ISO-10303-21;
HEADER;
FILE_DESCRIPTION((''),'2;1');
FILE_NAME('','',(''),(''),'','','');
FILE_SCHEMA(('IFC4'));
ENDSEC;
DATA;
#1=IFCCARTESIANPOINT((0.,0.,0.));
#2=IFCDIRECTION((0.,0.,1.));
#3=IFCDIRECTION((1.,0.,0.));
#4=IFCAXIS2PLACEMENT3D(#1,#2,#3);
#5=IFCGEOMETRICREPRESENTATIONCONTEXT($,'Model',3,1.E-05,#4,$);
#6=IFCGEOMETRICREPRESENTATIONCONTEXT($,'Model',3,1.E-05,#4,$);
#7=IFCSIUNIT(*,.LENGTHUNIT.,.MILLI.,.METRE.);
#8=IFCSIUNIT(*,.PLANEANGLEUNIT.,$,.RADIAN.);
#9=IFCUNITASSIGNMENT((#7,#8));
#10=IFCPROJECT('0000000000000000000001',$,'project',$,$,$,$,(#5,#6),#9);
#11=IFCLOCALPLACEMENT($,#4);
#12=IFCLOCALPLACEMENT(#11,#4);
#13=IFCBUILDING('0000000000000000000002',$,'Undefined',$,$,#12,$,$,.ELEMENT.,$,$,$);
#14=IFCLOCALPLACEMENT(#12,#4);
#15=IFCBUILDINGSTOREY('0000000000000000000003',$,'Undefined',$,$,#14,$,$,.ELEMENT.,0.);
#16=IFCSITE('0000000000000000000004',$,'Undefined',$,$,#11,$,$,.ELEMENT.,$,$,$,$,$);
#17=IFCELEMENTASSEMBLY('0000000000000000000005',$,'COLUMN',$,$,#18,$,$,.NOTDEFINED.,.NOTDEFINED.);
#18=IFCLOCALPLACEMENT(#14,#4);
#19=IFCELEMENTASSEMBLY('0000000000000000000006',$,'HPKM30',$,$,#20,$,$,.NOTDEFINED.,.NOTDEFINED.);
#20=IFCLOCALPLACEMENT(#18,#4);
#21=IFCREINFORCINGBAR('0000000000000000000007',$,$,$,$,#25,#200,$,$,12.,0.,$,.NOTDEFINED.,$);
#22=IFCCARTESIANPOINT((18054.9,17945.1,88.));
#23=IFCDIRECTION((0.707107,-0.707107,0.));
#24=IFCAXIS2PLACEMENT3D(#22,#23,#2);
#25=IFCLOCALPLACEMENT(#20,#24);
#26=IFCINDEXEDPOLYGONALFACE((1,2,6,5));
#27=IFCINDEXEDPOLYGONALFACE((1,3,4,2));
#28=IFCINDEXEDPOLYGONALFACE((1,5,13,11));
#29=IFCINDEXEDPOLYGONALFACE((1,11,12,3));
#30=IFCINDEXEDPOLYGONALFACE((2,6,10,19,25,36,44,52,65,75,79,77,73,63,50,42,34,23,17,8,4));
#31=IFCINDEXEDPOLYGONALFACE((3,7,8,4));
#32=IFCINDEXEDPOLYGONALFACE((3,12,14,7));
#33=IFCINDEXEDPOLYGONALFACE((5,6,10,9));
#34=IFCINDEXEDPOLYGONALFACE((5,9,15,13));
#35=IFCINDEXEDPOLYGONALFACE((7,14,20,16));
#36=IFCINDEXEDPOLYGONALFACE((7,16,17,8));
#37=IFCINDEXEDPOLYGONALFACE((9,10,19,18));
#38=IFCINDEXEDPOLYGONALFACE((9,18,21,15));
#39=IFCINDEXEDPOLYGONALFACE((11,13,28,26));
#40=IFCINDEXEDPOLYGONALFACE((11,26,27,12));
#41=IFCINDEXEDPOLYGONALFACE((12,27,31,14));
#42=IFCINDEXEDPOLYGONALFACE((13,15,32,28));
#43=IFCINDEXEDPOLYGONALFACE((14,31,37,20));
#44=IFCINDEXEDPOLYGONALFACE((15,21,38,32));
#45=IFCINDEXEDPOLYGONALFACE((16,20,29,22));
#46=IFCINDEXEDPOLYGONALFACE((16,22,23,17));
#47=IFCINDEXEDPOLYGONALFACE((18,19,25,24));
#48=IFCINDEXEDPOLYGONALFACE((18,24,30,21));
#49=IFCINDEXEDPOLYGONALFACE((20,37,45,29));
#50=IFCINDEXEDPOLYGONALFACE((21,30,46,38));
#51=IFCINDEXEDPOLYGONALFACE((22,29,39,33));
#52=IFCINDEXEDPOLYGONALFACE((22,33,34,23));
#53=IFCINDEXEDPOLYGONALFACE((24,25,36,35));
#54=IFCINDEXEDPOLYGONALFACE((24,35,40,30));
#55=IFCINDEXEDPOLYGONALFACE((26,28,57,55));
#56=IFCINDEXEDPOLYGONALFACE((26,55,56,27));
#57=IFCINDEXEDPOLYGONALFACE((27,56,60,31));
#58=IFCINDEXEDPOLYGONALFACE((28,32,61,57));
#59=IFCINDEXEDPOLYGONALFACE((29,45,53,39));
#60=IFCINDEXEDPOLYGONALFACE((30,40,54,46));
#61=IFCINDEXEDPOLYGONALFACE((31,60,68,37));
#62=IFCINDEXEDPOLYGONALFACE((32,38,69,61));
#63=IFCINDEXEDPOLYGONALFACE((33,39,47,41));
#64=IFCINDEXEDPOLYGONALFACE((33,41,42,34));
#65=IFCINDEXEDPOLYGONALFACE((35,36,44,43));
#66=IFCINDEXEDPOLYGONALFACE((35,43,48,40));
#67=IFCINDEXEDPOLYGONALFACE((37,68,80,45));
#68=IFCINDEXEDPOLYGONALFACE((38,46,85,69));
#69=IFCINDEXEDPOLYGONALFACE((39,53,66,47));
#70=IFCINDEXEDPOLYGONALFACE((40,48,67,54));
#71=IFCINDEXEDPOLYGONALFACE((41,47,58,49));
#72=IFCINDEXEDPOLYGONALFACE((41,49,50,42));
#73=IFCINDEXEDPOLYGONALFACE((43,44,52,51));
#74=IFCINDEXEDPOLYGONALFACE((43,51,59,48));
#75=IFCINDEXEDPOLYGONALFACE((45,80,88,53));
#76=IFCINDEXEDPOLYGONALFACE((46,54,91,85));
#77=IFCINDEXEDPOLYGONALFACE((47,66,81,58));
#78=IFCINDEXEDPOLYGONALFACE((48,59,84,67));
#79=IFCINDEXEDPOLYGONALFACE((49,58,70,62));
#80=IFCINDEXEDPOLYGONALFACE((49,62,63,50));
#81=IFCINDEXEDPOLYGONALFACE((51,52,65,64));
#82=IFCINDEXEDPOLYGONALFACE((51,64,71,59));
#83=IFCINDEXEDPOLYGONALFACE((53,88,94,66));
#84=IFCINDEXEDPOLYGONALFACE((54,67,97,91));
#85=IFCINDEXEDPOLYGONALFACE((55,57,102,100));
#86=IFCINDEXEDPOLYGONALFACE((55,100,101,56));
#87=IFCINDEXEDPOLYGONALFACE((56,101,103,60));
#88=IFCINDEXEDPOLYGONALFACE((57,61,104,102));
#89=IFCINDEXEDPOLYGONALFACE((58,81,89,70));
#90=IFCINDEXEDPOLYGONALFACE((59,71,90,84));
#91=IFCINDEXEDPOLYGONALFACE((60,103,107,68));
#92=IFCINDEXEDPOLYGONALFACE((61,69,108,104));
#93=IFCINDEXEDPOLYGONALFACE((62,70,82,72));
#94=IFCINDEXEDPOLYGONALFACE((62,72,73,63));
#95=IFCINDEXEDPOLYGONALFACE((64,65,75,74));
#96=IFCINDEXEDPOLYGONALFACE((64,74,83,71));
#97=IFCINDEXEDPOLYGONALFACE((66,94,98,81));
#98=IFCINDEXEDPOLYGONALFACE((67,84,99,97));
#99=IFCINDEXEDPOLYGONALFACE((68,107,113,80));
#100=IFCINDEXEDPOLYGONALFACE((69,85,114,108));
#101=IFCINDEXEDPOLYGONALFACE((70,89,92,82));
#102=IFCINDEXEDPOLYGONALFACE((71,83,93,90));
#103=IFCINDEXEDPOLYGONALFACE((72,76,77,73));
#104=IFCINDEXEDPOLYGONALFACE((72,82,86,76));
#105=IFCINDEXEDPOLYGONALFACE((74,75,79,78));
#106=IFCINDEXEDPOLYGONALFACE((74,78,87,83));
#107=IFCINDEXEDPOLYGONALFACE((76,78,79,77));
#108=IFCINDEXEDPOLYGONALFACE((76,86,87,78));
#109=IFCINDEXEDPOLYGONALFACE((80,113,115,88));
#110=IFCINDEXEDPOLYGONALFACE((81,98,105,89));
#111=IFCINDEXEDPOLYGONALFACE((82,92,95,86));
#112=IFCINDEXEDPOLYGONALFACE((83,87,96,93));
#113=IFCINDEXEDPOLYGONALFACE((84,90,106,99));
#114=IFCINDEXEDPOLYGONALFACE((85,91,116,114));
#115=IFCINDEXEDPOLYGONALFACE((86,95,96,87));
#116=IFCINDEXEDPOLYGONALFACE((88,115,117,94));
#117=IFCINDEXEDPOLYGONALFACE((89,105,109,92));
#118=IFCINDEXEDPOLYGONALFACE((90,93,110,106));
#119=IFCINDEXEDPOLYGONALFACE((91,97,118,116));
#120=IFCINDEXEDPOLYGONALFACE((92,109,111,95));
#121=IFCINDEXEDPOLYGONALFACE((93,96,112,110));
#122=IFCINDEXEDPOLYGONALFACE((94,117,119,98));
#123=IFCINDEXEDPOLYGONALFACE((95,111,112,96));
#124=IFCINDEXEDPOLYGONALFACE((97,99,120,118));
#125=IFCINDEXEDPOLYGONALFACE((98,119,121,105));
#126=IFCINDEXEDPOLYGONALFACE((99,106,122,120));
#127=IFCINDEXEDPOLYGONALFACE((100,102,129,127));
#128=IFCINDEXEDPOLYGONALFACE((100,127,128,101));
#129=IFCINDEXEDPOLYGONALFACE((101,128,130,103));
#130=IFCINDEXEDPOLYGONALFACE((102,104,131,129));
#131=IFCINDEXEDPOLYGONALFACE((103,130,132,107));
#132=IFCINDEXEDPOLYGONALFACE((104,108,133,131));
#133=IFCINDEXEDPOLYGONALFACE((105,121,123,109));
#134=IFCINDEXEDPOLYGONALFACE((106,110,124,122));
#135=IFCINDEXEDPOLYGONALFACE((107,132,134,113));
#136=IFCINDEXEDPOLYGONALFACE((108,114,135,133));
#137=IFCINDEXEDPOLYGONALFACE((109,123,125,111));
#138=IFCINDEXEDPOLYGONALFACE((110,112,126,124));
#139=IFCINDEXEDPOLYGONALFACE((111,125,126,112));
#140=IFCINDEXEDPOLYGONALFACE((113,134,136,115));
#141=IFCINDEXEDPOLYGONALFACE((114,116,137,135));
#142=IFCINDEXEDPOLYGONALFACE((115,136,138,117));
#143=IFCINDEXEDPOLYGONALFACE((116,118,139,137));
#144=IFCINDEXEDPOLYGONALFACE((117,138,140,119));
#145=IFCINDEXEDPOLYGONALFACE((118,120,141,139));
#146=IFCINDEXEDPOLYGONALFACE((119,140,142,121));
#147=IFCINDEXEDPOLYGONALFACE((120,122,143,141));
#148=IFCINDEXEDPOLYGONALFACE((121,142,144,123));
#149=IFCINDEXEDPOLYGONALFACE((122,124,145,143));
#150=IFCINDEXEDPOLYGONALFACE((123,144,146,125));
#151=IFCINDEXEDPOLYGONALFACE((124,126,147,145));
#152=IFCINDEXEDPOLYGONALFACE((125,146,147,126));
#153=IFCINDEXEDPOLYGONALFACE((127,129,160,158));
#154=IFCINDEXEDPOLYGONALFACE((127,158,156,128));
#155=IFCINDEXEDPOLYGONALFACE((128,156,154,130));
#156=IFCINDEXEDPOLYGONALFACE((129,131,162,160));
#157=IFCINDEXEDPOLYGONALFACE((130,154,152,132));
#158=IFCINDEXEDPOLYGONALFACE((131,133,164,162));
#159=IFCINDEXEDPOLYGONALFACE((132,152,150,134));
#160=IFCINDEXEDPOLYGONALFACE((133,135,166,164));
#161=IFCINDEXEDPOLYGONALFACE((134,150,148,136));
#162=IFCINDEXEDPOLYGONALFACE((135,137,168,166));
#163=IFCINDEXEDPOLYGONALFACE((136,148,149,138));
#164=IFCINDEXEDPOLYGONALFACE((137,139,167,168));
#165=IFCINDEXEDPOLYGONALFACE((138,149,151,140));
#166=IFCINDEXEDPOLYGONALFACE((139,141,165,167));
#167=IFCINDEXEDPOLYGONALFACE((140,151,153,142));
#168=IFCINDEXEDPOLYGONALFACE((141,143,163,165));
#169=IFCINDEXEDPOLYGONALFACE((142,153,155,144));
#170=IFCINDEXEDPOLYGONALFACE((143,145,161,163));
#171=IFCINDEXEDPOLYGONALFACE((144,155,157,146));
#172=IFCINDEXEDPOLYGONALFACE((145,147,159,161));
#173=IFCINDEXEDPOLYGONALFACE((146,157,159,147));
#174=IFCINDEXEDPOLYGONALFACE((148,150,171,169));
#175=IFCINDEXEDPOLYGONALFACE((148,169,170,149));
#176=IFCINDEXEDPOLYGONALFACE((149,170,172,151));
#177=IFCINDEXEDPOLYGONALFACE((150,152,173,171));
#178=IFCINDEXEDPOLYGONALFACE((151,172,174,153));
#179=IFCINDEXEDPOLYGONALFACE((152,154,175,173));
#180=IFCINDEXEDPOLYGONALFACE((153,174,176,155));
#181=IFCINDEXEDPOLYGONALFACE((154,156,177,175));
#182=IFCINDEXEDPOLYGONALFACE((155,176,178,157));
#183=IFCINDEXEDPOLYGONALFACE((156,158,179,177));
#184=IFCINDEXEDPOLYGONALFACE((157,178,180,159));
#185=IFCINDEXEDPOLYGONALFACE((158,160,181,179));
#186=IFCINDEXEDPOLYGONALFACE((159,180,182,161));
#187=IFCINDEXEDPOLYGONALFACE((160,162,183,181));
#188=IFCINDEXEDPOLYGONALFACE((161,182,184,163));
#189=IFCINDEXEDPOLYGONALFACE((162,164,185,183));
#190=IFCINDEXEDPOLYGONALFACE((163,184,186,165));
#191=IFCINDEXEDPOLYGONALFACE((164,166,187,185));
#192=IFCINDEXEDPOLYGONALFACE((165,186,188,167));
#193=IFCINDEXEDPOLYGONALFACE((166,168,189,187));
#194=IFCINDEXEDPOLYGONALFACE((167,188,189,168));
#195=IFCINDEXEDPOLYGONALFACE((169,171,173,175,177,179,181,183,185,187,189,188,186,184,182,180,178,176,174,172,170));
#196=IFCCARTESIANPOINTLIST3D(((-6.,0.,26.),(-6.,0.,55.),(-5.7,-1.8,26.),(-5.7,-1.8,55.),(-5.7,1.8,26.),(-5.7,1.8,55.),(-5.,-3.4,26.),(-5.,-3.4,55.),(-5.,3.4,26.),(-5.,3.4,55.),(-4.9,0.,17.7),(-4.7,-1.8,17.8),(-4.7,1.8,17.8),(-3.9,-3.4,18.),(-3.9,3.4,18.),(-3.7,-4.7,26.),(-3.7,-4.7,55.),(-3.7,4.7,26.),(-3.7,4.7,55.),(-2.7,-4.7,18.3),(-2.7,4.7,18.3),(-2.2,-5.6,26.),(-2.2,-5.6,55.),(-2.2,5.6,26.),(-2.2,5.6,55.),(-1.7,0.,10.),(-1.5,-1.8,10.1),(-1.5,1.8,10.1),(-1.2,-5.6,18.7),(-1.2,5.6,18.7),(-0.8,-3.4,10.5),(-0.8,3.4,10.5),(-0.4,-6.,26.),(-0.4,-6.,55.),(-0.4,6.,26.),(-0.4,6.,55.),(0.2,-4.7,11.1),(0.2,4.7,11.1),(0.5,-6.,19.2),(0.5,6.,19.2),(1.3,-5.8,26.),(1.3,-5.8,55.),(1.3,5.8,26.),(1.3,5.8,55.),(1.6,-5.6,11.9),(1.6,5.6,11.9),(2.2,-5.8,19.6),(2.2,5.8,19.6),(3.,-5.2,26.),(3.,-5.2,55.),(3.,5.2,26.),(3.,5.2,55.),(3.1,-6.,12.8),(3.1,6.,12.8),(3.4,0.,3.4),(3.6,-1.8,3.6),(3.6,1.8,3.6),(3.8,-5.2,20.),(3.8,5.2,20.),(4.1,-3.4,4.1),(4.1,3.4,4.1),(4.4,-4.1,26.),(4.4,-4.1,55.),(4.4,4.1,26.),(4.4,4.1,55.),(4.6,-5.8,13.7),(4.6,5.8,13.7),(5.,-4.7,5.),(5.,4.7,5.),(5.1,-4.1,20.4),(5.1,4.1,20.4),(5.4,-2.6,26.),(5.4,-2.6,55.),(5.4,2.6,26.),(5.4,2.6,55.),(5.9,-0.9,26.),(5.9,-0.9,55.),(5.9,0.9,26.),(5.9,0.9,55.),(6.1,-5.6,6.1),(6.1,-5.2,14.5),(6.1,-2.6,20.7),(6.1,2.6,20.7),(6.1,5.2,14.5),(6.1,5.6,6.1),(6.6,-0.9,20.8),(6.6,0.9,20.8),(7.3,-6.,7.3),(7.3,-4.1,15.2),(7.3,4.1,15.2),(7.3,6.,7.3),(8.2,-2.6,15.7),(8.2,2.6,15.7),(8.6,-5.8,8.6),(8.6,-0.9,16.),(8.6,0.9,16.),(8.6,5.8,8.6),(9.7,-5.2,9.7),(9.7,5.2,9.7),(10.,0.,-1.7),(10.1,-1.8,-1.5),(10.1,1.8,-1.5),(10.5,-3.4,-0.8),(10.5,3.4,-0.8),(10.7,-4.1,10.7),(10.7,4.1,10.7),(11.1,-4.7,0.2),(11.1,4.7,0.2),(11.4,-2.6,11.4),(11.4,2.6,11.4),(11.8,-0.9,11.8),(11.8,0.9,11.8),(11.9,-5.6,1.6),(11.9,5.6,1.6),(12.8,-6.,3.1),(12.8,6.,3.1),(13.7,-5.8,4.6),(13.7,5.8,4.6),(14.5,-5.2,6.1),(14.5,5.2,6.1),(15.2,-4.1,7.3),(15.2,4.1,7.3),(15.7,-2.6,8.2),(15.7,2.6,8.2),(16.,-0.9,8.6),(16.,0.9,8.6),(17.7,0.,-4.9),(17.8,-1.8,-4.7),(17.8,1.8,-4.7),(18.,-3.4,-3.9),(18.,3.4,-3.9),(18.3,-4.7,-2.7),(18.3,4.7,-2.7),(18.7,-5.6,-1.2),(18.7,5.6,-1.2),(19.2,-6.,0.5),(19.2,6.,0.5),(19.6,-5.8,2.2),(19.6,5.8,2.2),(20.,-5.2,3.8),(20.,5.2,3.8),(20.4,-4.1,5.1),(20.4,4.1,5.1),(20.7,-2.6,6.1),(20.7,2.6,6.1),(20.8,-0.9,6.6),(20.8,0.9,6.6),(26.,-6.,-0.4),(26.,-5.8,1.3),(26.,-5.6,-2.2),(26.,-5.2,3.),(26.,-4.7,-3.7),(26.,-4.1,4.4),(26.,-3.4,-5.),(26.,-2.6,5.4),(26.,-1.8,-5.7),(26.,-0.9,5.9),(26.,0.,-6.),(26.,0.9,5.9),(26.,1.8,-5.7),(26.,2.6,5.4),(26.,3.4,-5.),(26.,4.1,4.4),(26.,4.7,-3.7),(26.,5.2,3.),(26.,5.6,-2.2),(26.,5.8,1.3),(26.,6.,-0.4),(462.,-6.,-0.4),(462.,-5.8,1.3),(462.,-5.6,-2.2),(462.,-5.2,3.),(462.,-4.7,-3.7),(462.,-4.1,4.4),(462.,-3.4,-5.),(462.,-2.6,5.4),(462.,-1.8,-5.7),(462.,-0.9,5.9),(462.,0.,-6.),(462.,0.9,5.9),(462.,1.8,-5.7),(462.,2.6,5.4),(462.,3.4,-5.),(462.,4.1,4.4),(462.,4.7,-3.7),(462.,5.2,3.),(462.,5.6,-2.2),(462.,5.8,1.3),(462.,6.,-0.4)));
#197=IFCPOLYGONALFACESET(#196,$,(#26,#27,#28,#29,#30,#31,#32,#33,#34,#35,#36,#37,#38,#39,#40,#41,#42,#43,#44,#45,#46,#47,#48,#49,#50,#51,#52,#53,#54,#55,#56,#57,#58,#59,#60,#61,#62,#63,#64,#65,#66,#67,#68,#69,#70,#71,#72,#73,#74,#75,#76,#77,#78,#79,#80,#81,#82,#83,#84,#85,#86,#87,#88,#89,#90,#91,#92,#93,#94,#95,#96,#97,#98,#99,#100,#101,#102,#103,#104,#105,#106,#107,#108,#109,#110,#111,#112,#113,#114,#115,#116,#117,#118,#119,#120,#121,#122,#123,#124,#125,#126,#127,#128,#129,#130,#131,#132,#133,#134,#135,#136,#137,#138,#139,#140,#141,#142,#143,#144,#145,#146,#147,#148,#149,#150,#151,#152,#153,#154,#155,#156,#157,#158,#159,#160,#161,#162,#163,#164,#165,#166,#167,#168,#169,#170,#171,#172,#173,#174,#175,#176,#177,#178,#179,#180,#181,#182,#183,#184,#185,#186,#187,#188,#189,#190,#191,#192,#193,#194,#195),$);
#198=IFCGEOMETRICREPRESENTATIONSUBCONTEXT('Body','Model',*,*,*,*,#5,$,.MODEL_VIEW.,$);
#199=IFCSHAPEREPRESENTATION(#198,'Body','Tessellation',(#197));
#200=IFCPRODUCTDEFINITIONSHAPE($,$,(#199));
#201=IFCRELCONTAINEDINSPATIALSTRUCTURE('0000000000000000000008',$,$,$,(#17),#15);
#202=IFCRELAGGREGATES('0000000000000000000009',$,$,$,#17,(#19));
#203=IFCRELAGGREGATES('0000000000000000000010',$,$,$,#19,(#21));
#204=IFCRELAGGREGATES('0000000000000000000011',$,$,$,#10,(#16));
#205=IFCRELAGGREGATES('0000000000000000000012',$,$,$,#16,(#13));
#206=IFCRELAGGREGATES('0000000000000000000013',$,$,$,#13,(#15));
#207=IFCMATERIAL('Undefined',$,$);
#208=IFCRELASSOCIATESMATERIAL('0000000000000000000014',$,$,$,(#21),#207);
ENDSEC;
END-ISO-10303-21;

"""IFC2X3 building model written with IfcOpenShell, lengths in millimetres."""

from ifc_helpers import new_model, entity, si_unit, frame, origin_with_axes, place, context, subcontext, project, spatial, source, transform, mapped, material, element, aggregate, save


model = new_model("IFC2X3")

# Units and contexts
model_context_1 = context("Model", 3, precision=1e-05, world=origin_with_axes())
model_context_2 = context("Model", 3, precision=1e-05, world=origin_with_axes())
body_context = subcontext(model_context_1, "Body", "Model", "MODEL_VIEW")
ifc_project = project(units=[si_unit("LENGTHUNIT", "METRE", prefix="MILLI"), si_unit("PLANEANGLEUNIT", "RADIAN")], contexts=[model_context_1, model_context_2])

# Site, building, storey
site_placement = place(None, origin_with_axes())
site = spatial("IfcSite", under=ifc_project, at=site_placement, Name="Undefined", CompositionType="ELEMENT")
building_placement = place(site_placement, origin_with_axes())
building = spatial("IfcBuilding", under=site, at=building_placement, Name="Undefined", CompositionType="ELEMENT")
storey_placement = place(building_placement, origin_with_axes())
storey = spatial("IfcBuildingStorey", under=building, at=storey_placement, Name="Undefined", CompositionType="ELEMENT", Elevation=0.0)

# Element assembly
assembly_1_placement = place(storey_placement, origin_with_axes())
assembly_1 = element("IfcElementAssembly", 1, at=assembly_1_placement, inside=storey, Name="COLUMN", AssemblyPlace="NOTDEFINED", PredefinedType="NOTDEFINED")

# Shared definitions
ifc_material_1 = material(Name="Undefined")

# Element assembly
assembly_2_placement = place(assembly_1_placement, origin_with_axes())
assembly_2 = element("IfcElementAssembly", 2, at=assembly_2_placement, Name="HPKM30", AssemblyPlace="NOTDEFINED", PredefinedType="NOTDEFINED")
aggregate(assembly_1, [assembly_2])

# Reinforcing bar
shared_shape_1 = source(origin_with_axes(), body_context, "Body", "AdvancedSweptSolid", [
    entity("IfcSweptDiskSolid", entity("IfcCompositeCurve", [entity("IfcCompositeCurveSegment", "CONTINUOUS", True, entity("IfcTrimmedCurve", entity("IfcLine", entity("IfcCartesianPoint", [0.0, 0.0, 0.0]), entity("IfcVector", entity("IfcDirection", [0.0, 0.0, -1.0]), 1.0)), [entity("IfcParameterValue", 0.0)], [entity("IfcParameterValue", 29.0)], True, "PARAMETER")), entity("IfcCompositeCurveSegment", "CONTINUOUS", True, entity("IfcTrimmedCurve", entity("IfcCircle", entity("IfcAxis2Placement3D", entity("IfcCartesianPoint", [26.0, 0.0, -29.0]), entity("IfcDirection", [0.0, -1.0, 0.0]), entity("IfcDirection", [-1.0, 0.0, 0.0])), 26.0), [entity("IfcParameterValue", 0.0)], [entity("IfcParameterValue", 1.570796)], True, "PARAMETER")), entity("IfcCompositeCurveSegment", "DISCONTINUOUS", True, entity("IfcTrimmedCurve", entity("IfcLine", entity("IfcCartesianPoint", [26.0, 0.0, -55.0]), entity("IfcVector", entity("IfcDirection", [1.0, 0.0, 0.0]), 1.0)), [entity("IfcParameterValue", 0.0)], [entity("IfcParameterValue", 436.0)], True, "PARAMETER"))], False), 6.0, None, 0.0, 466.6),
])
reinforcing_bar_1_placement = place(assembly_2_placement, frame((18054.9, 17945.1, 88.0), z_axis=(0.707107, -0.707107, 0.0), x_axis=(0.0, 0.0, 1.0)))
reinforcing_bar_1 = element("IfcReinforcingBar", 3, at=reinforcing_bar_1_placement, material=ifc_material_1, BarRole="NOTDEFINED", CrossSectionArea=0.0, NominalDiameter=12.0, context=body_context, shape_type="MappedRepresentation", body=[
    mapped(shared_shape_1, transform((0.0, 0.0, 55.0))),
])
aggregate(assembly_2, [reinforcing_bar_1])

save(model, "model.ifc")
